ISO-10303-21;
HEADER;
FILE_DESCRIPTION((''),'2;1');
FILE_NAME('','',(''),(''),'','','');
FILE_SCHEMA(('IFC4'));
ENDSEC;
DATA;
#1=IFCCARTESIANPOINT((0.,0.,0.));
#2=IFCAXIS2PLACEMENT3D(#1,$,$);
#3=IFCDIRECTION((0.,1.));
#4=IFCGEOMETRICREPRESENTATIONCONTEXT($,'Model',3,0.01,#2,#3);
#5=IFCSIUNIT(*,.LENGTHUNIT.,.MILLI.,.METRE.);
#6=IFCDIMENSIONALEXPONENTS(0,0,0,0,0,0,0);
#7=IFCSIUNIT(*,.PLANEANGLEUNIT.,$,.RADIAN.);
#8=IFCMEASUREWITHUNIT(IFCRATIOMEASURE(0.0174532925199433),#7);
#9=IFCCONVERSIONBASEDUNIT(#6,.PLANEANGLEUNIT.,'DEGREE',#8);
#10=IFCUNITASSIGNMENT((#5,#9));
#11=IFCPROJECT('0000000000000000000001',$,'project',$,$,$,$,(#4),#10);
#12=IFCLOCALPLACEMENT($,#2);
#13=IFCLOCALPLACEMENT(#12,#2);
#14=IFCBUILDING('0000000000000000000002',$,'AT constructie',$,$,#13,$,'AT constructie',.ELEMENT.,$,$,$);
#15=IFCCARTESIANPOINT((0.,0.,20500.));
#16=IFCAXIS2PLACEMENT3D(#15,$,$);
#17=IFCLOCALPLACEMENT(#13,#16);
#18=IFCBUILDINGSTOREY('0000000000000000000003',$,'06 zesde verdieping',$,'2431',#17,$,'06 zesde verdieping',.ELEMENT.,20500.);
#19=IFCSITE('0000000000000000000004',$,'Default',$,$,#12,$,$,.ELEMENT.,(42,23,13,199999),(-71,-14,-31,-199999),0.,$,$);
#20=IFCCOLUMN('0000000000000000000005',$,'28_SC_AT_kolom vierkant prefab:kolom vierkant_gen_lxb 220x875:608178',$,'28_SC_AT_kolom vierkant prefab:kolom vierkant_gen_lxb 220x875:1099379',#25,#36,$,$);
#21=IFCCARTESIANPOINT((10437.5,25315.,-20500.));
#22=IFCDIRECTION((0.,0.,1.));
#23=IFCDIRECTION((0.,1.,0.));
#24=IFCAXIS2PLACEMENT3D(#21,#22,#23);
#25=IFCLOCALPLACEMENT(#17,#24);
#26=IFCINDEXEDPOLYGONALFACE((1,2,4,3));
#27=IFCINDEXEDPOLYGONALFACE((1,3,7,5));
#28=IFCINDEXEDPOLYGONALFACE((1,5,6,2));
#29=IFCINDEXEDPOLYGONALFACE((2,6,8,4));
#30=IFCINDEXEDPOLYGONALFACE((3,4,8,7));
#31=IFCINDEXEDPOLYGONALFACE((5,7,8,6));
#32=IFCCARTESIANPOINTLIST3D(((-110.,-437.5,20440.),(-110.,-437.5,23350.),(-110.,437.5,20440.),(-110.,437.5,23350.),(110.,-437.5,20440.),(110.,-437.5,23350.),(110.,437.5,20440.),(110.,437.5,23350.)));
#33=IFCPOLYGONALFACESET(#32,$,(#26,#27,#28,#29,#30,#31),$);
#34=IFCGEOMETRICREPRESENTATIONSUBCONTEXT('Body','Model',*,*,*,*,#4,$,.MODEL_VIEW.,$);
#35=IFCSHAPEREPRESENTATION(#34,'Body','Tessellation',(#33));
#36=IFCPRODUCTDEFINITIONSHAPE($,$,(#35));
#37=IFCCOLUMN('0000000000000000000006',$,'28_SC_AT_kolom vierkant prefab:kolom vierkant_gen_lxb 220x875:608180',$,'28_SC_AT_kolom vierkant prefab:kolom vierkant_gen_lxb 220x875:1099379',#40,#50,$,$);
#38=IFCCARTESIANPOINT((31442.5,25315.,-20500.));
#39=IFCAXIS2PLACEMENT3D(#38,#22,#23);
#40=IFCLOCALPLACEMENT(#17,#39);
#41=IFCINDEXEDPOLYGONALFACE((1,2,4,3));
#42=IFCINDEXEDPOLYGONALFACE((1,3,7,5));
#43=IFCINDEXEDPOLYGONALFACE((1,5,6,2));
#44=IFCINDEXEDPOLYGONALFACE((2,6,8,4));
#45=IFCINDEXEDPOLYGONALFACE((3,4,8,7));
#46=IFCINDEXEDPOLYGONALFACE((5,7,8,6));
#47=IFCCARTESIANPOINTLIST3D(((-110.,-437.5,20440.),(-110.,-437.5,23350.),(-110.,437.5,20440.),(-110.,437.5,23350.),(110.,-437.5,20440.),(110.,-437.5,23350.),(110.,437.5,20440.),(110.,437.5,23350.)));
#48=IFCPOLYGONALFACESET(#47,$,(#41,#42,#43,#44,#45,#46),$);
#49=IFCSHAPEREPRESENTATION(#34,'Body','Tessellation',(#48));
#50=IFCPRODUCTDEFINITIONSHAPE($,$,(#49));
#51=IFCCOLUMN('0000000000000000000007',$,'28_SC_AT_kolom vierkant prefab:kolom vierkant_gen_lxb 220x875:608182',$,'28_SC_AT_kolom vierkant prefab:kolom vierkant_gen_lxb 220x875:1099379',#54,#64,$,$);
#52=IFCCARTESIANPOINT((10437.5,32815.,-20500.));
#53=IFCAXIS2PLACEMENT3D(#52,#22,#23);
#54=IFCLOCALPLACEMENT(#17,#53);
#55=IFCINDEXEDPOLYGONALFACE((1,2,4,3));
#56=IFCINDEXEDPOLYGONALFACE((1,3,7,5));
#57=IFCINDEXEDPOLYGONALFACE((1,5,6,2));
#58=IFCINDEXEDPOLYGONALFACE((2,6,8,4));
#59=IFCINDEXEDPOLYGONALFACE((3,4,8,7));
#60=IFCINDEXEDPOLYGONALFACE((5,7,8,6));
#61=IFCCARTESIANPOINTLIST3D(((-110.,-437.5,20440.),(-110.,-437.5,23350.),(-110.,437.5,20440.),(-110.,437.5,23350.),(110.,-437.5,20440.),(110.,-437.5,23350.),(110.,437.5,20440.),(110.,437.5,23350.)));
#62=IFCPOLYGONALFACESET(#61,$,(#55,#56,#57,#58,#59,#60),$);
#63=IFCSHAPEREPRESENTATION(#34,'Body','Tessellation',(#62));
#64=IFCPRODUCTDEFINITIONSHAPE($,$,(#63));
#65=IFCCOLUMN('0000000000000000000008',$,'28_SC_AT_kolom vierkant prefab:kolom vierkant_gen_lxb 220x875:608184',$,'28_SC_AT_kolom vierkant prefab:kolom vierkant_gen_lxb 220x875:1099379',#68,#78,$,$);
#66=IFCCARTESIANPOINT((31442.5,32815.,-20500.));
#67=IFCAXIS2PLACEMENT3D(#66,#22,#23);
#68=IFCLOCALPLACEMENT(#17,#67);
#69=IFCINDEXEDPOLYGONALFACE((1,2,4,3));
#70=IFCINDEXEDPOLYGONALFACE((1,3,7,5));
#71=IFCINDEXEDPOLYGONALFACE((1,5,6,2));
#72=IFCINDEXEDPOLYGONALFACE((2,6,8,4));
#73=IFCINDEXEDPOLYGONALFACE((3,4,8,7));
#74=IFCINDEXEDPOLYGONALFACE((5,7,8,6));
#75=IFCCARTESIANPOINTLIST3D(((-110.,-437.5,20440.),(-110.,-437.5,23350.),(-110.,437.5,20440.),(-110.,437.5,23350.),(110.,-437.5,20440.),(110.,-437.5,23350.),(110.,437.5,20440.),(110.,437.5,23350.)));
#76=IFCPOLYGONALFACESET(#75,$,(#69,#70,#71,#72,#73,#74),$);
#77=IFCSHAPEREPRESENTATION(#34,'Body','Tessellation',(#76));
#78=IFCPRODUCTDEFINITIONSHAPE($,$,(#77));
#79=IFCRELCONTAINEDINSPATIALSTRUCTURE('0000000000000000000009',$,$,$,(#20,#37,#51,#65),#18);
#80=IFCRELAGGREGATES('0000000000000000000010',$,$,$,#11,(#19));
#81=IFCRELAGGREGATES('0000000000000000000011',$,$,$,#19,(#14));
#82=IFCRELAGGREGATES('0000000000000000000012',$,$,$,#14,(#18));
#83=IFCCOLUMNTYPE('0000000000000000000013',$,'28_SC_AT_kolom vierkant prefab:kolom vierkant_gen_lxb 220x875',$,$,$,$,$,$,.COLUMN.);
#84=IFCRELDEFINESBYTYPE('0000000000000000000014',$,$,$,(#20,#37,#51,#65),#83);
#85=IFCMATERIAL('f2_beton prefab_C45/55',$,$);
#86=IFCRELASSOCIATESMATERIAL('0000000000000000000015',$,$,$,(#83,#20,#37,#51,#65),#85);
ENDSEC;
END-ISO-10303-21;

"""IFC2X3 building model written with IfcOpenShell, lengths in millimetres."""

from ifc_helpers import new_model, entity, si_unit, converted_unit, direction, frame, origin, origin_2d_with_axis, place, context, subcontext, project, spatial, rectangle, extrude, source, transform, mapped, material, type_object, type_shapes, element, save


model = new_model("IFC2X3")

# Units and contexts
model_context = context("Model", 3, precision=0.01, world=origin(), true_north=direction((0.0, 1.0)))
body_context = subcontext(model_context, "Body", "Model", "MODEL_VIEW")
ifc_project = project(units=[si_unit("LENGTHUNIT", "METRE", prefix="MILLI"), converted_unit("PLANEANGLEUNIT", "DEGREE", entity("IfcRatioMeasure", 0.0174532925199433), si_unit("PLANEANGLEUNIT", "RADIAN"), dimensions=[0, 0, 0, 0, 0, 0, 0])], contexts=[model_context])

# Site, building, storey
site_placement = place(None, origin())
site = spatial("IfcSite", under=ifc_project, at=site_placement, Name="Default", CompositionType="ELEMENT", RefLatitude=(42, 23, 13, 199999), RefLongitude=(-71, -14, -31, -199999), RefElevation=0.0)
building_placement = place(site_placement, origin())
building = spatial("IfcBuilding", under=site, at=building_placement, Name="AT constructie", LongName="AT constructie", CompositionType="ELEMENT")
storey_placement = place(building_placement, frame((0.0, 0.0, 20500.0)))
storey = spatial("IfcBuildingStorey", under=building, at=storey_placement, Name="06 zesde verdieping", ObjectType="2431", LongName="06 zesde verdieping", CompositionType="ELEMENT", Elevation=20500.0)

# Columns
ifc_material_1 = material(Name="f2_beton prefab_C45/55")
column_type = type_object("IfcColumnType", Name="28_SC_AT_kolom vierkant prefab:kolom vierkant_gen_lxb 220x875", PredefinedType="COLUMN", material=ifc_material_1)
shared_shape = source(origin(), body_context, "Body", "SweptSolid", [
    extrude(rectangle(XDim=220.0, YDim=875.0, at=origin_2d_with_axis()), frame((0.0, 0.0, 20440.0), z_axis=(0.0, 0.0, 1.0), x_axis=(-1.0, 0.0, 0.0)), (0.0, 0.0, 1.0), 2910.0),
])
type_shapes(column_type, [shared_shape])
for number, where, z_axis, x_axis, name in (
    (1, (10437.5, 25315.0, -20500.0), (0.0, 0.0, 1.0), (0.0, 1.0, 0.0), "28_SC_AT_kolom vierkant prefab:kolom vierkant_gen_lxb 220x875:608178"),
    (2, (31442.5, 25315.0, -20500.0), (0.0, 0.0, 1.0), (0.0, 1.0, 0.0), "28_SC_AT_kolom vierkant prefab:kolom vierkant_gen_lxb 220x875:608180"),
    (3, (10437.5, 32815.0, -20500.0), (0.0, 0.0, 1.0), (0.0, 1.0, 0.0), "28_SC_AT_kolom vierkant prefab:kolom vierkant_gen_lxb 220x875:608182"),
    (4, (31442.5, 32815.0, -20500.0), (0.0, 0.0, 1.0), (0.0, 1.0, 0.0), "28_SC_AT_kolom vierkant prefab:kolom vierkant_gen_lxb 220x875:608184"),
):
    element("IfcColumn", number, at=place(storey_placement, frame(where, z_axis=z_axis, x_axis=x_axis)), inside=storey, type_object=column_type, material=ifc_material_1, Name=name, ObjectType="28_SC_AT_kolom vierkant prefab:kolom vierkant_gen_lxb 220x875:1099379", context=body_context, shape_type="MappedRepresentation", body=[
        mapped(shared_shape, transform((0.0, 0.0, 0.0), scale=1.0)),
    ])

save(model, "model.ifc")
